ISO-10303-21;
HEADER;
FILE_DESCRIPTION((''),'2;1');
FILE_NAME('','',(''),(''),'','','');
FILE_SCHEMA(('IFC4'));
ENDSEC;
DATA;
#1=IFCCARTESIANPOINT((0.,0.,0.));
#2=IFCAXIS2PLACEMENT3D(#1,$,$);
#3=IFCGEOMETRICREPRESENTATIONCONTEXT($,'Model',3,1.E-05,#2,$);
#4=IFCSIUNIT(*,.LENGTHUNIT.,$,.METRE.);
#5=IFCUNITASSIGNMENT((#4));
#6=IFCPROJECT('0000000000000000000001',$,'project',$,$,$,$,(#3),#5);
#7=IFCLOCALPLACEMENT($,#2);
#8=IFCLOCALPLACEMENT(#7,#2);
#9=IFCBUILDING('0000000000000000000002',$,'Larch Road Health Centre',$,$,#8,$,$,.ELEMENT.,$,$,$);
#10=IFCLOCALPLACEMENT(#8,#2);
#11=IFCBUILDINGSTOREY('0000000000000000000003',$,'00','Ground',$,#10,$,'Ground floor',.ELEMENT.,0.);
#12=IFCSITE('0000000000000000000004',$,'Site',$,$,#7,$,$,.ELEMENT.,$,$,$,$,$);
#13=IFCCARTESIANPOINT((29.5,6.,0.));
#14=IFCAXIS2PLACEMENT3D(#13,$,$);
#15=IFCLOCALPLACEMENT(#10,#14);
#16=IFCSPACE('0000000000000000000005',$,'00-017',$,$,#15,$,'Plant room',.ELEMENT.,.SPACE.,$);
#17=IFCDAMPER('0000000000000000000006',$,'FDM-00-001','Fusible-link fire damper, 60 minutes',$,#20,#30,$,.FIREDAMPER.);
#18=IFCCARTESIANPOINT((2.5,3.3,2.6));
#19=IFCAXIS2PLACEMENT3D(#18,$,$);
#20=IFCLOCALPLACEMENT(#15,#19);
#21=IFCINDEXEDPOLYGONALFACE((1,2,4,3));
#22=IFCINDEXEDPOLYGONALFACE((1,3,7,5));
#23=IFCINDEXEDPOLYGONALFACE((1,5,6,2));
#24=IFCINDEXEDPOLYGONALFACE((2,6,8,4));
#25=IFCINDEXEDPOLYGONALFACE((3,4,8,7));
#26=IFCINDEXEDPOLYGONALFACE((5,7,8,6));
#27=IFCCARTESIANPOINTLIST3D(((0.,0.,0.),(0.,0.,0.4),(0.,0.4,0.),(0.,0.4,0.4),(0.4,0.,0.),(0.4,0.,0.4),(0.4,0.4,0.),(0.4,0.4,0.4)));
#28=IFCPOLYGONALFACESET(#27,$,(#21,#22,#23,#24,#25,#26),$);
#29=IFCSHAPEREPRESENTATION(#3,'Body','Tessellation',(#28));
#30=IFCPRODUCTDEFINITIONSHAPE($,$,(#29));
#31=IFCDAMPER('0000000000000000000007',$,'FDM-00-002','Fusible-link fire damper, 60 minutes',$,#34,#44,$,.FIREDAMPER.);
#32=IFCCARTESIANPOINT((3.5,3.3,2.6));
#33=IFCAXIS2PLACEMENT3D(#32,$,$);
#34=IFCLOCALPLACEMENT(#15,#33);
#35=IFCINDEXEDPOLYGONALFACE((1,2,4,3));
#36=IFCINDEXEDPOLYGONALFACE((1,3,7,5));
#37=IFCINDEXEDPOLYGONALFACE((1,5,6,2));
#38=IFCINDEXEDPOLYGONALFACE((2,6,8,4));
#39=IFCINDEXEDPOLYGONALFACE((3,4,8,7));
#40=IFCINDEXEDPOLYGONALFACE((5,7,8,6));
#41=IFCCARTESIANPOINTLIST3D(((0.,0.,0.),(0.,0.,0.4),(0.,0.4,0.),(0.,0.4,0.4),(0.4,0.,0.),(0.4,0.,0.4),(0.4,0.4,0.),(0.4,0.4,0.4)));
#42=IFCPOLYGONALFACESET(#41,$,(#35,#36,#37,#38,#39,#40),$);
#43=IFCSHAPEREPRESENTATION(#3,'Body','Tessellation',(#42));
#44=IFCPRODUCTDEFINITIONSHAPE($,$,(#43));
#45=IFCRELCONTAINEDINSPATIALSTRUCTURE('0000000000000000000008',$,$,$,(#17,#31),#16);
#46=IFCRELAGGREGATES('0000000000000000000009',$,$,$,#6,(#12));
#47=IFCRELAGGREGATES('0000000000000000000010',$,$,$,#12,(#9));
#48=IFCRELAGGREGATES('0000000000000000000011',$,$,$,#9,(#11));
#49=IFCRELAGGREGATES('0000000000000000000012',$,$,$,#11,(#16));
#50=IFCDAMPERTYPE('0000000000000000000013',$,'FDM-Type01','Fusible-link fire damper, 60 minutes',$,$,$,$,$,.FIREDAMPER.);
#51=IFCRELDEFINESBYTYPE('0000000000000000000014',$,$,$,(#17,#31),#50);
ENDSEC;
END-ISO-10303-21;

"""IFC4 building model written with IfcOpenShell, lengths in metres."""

from ifc_helpers import new_model, si_unit, frame, frame_2d, origin, place, context, project, spatial, rectangle, extrude, type_object, element, save


model = new_model("IFC4")

# Units and contexts
model_context = context("Model", 3, precision=1e-05, world=origin())
ifc_project = project(units=[si_unit("LENGTHUNIT", "METRE")], contexts=[model_context])

# Site, building, storey, space
site_placement = place(None, origin())
site = spatial("IfcSite", under=ifc_project, at=site_placement, Name="Site", CompositionType="ELEMENT")
building_placement = place(site_placement, origin())
building = spatial("IfcBuilding", under=site, at=building_placement, Name="Larch Road Health Centre", CompositionType="ELEMENT")
storey_placement = place(building_placement, origin())
storey = spatial("IfcBuildingStorey", under=building, at=storey_placement, Name="00", Description="Ground", LongName="Ground floor", CompositionType="ELEMENT", Elevation=0.0)
space_1_placement = place(storey_placement, frame((29.5, 6.0, 0.0)))
space_1 = spatial("IfcSpace", under=storey, at=space_1_placement, Name="00-017", LongName="Plant room", CompositionType="ELEMENT", PredefinedType="SPACE")

# Dampers
damper_type = type_object("IfcDamperType", Name="FDM-Type01", Description="Fusible-link fire damper, 60 minutes", PredefinedType="FIREDAMPER")
for number, where, name in (
    (1, (2.5, 3.3, 2.6), "FDM-00-001"),
    (2, (3.5, 3.3, 2.6), "FDM-00-002"),
):
    element("IfcDamper", number, at=place(space_1_placement, frame(where)), inside=space_1, type_object=damper_type, Name=name, Description="Fusible-link fire damper, 60 minutes", PredefinedType="FIREDAMPER", context=model_context, shape_type="SweptSolid", body=[
        extrude(rectangle(XDim=0.4, YDim=0.4, at=frame_2d((0.2, 0.2))), origin(), (0.0, 0.0, 1.0), 0.4),
    ])

save(model, "model.ifc")
